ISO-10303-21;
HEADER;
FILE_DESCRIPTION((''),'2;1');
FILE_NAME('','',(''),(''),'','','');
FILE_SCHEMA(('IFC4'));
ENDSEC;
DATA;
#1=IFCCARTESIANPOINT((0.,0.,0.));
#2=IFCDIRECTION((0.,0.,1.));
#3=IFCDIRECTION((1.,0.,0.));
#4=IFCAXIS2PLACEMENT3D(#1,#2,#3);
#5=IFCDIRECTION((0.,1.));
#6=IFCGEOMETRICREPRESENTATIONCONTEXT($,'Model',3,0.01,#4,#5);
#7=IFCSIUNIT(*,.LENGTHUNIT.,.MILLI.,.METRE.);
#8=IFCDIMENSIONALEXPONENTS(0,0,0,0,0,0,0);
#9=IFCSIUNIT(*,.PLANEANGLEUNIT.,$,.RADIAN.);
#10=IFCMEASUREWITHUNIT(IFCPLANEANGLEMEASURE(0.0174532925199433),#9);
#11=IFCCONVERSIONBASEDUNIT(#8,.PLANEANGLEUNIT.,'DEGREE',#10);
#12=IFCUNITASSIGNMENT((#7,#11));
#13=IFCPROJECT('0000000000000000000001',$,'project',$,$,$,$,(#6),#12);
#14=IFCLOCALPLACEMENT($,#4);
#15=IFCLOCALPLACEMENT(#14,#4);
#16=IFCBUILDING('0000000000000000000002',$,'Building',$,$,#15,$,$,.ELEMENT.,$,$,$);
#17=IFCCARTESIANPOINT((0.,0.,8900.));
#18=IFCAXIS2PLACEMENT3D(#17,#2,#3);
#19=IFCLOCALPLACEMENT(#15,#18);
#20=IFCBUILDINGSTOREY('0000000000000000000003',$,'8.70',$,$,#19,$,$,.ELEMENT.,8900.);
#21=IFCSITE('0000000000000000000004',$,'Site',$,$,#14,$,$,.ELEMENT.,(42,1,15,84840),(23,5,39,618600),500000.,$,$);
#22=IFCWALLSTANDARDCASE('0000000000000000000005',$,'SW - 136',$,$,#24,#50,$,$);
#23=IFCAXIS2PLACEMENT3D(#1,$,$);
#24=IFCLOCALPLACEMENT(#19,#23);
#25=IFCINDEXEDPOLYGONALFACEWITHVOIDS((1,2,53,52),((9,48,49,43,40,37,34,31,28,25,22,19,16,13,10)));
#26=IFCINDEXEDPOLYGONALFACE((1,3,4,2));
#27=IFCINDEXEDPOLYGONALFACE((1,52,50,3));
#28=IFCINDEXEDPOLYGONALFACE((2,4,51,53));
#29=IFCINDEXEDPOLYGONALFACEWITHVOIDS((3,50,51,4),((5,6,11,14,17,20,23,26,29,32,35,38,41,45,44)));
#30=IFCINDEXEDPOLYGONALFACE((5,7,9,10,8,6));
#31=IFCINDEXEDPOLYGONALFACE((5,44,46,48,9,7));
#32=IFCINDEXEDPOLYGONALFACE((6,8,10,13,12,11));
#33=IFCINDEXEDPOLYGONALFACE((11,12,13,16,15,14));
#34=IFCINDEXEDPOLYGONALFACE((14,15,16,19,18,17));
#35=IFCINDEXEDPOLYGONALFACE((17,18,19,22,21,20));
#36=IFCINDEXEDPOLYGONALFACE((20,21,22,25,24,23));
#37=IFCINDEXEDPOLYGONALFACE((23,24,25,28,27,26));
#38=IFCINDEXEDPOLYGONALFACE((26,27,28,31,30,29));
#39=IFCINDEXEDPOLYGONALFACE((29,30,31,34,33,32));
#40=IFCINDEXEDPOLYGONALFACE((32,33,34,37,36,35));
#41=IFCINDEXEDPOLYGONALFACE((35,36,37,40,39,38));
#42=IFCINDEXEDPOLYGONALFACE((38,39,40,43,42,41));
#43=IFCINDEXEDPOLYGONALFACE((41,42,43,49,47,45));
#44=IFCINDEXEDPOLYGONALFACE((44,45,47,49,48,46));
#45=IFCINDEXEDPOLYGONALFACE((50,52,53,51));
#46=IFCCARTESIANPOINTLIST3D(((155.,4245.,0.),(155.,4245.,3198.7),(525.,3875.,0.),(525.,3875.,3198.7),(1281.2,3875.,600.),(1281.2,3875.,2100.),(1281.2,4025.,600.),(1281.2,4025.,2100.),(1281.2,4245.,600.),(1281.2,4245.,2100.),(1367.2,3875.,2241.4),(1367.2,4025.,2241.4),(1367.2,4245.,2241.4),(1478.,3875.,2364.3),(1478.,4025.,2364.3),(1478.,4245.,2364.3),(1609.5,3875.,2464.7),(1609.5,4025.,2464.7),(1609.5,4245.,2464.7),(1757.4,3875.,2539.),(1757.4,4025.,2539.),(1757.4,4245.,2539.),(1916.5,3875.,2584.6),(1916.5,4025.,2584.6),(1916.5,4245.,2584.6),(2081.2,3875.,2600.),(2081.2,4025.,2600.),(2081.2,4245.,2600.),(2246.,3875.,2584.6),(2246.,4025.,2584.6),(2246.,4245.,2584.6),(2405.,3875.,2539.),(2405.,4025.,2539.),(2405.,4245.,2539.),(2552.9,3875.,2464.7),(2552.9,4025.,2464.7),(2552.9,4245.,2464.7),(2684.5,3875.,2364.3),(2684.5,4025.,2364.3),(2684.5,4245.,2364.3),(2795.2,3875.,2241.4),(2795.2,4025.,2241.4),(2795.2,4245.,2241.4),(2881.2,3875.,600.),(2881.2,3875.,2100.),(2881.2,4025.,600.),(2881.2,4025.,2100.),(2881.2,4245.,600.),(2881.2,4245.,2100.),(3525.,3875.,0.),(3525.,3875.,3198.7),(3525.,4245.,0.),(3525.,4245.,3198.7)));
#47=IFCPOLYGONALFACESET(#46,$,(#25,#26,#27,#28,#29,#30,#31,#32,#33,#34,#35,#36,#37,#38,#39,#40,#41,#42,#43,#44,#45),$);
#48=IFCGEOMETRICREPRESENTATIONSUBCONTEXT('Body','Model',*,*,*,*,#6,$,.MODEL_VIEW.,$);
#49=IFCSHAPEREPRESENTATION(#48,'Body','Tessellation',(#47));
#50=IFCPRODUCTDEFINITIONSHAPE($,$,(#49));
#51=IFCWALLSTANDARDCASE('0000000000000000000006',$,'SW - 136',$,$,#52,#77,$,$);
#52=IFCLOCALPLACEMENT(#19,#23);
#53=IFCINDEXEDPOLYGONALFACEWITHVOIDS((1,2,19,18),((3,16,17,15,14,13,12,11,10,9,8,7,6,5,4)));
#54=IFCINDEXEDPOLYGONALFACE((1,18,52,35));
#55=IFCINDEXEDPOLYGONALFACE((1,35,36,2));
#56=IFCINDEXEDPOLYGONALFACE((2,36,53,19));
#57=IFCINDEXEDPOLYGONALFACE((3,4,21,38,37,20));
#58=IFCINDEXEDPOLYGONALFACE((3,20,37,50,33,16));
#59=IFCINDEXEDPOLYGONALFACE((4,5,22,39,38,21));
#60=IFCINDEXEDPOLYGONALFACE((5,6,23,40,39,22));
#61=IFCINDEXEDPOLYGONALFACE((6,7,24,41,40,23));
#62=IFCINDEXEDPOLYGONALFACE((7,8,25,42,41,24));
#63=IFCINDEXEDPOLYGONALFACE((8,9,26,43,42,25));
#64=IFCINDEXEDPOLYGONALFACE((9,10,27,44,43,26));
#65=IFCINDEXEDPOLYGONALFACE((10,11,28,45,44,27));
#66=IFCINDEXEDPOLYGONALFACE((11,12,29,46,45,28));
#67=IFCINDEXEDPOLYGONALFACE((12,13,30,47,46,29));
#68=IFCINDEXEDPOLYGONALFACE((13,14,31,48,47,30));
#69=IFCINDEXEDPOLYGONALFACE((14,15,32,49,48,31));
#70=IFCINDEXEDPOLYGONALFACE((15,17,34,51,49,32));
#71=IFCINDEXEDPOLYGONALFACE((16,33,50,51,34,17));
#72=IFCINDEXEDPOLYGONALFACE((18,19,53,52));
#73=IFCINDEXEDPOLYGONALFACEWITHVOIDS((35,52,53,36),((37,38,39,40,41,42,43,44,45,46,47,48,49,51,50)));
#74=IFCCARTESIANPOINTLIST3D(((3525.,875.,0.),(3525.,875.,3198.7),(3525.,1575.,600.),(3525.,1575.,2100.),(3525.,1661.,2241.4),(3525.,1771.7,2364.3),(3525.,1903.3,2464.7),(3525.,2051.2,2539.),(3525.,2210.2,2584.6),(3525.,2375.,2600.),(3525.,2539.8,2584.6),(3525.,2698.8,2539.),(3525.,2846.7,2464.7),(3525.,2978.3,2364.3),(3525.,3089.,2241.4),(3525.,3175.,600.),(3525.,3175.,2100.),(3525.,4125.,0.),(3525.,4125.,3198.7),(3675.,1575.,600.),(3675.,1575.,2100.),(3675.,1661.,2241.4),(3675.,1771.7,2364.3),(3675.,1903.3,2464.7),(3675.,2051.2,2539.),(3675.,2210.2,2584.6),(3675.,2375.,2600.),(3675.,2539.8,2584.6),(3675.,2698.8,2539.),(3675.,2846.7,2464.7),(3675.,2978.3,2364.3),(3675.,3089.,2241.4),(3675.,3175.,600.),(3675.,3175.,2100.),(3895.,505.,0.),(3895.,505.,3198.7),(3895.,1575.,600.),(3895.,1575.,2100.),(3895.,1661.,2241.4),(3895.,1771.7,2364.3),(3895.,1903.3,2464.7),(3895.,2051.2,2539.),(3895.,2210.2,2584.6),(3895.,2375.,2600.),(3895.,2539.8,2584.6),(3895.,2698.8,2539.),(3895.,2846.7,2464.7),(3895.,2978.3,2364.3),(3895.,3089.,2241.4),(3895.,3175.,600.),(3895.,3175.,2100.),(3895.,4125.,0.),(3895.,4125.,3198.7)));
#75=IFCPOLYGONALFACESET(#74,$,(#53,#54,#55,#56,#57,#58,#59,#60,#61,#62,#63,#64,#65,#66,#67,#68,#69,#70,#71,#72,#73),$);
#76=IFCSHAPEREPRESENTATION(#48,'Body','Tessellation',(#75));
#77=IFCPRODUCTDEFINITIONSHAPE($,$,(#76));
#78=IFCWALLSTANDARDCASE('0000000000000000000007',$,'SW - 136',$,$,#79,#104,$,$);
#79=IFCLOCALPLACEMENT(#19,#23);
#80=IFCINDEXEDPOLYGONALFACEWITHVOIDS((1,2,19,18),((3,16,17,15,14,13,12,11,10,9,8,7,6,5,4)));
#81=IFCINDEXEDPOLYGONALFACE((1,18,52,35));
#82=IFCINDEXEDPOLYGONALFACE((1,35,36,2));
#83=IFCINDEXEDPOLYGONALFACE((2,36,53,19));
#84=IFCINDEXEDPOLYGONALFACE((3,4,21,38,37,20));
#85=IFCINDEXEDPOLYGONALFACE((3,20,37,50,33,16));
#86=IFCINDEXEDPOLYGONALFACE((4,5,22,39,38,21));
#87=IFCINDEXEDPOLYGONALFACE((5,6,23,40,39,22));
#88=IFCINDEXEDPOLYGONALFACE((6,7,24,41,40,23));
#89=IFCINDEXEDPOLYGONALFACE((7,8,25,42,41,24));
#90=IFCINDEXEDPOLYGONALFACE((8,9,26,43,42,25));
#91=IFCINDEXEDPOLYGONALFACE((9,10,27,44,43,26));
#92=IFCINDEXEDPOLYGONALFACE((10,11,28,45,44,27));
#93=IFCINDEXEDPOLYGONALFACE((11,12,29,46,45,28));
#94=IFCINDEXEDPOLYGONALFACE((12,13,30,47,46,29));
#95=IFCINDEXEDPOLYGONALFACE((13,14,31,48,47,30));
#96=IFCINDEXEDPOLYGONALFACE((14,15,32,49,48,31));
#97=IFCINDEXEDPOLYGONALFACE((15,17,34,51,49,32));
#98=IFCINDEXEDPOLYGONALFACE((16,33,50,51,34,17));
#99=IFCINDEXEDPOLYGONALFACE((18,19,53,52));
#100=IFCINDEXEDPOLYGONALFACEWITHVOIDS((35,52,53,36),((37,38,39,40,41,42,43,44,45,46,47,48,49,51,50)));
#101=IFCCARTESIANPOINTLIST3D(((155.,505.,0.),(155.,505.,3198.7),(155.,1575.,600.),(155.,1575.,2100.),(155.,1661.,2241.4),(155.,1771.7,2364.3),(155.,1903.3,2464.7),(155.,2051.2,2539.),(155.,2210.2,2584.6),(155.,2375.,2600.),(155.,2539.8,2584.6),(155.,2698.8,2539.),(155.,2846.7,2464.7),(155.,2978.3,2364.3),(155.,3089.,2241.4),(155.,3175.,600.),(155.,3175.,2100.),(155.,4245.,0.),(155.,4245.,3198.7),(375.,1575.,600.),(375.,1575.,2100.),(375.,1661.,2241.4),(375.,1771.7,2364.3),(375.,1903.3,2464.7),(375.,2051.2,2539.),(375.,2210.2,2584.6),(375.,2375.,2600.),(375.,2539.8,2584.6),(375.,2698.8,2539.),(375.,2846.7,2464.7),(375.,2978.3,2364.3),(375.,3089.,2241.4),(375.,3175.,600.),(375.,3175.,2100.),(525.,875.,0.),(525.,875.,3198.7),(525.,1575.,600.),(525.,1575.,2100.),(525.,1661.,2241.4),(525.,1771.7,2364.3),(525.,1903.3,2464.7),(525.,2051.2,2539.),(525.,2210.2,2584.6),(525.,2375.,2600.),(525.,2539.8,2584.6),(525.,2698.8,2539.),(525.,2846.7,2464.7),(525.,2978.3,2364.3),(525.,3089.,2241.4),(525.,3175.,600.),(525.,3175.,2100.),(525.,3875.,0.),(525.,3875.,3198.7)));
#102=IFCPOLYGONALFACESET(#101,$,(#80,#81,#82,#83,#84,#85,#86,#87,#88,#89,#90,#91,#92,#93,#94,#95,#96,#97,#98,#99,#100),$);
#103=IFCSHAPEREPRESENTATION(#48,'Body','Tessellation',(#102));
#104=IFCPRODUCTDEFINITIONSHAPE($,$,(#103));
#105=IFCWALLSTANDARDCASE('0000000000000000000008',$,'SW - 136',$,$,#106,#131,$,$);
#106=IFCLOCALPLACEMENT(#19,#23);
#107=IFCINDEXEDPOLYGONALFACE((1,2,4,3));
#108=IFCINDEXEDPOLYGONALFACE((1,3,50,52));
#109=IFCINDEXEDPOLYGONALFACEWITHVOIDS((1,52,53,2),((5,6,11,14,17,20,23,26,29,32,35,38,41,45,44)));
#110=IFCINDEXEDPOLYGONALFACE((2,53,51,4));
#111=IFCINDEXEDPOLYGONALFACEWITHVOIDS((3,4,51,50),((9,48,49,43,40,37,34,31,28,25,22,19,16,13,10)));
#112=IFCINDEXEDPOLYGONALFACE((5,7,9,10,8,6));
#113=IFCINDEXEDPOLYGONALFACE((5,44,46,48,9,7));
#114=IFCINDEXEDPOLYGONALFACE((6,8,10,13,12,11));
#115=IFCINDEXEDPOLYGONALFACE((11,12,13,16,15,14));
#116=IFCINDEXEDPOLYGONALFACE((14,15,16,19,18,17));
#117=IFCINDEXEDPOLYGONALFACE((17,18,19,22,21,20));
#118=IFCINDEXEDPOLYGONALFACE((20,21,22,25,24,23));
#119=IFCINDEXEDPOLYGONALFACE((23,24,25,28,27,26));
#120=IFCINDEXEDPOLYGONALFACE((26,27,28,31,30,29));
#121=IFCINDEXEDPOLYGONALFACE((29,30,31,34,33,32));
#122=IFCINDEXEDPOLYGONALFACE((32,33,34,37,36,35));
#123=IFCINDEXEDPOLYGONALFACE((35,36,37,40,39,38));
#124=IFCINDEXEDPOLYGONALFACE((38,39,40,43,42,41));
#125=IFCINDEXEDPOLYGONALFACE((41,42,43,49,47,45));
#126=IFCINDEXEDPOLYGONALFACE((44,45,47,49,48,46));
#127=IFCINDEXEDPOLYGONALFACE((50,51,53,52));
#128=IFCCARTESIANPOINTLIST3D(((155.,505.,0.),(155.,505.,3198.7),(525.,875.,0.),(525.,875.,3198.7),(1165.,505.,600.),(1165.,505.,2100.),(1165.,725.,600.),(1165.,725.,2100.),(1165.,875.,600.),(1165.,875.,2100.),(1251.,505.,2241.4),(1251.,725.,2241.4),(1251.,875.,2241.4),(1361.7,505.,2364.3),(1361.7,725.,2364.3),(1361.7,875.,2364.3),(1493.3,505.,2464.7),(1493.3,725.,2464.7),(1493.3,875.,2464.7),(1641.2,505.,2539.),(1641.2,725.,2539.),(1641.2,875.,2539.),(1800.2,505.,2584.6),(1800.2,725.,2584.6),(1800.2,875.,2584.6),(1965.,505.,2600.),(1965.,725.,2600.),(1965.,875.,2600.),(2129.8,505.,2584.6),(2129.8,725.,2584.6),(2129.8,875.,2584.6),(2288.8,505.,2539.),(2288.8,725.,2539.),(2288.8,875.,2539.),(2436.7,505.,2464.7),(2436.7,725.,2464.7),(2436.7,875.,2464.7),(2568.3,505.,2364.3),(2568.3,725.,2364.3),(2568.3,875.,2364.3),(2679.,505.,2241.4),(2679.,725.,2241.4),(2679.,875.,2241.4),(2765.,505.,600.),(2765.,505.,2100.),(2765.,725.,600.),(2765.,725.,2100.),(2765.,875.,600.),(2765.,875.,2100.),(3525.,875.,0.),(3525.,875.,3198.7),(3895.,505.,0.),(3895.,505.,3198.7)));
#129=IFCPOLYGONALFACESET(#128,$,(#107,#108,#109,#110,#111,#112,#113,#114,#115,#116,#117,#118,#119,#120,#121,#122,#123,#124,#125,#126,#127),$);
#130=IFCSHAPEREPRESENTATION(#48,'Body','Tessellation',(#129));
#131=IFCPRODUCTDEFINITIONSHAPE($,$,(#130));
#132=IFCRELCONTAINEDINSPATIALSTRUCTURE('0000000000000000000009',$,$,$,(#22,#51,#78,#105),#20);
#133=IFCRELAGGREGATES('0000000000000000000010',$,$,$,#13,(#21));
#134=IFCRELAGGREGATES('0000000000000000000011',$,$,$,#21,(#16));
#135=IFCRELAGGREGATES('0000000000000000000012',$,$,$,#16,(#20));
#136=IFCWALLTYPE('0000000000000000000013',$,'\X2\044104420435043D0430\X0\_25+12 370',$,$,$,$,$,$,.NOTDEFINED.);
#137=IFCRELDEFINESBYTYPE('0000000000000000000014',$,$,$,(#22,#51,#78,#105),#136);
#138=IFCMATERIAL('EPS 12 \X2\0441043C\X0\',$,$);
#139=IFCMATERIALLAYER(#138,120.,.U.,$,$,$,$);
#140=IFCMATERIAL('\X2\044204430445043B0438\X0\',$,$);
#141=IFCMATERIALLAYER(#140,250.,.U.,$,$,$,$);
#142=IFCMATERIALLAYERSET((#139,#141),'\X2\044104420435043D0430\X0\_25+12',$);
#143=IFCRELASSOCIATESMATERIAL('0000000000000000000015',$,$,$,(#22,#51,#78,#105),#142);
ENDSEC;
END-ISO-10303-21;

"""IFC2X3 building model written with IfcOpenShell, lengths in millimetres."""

from ifc_helpers import new_model, entity, si_unit, converted_unit, direction, frame, origin_with_axes, place, context, subcontext, project, spatial, polyline, outline, extrude, material, layer, layer_set, layer_usage, type_object, element, save


model = new_model("IFC2X3")

# Units and contexts
model_context = context("Model", 3, precision=0.01, world=origin_with_axes(), true_north=direction((0.0, 1.0)))
body_context = subcontext(model_context, "Body", "Model", "MODEL_VIEW")
ifc_project = project(units=[si_unit("LENGTHUNIT", "METRE", prefix="MILLI"), converted_unit("PLANEANGLEUNIT", "DEGREE", entity("IfcPlaneAngleMeasure", 0.0174532925199433), si_unit("PLANEANGLEUNIT", "RADIAN"), dimensions=[0, 0, 0, 0, 0, 0, 0])], contexts=[model_context])

# Site, building, storey
site_placement = place(None, origin_with_axes())
site = spatial("IfcSite", under=ifc_project, at=site_placement, Name="Site", CompositionType="ELEMENT", RefLatitude=(42, 1, 15, 84840), RefLongitude=(23, 5, 39, 618600), RefElevation=500000.0)
building_placement = place(site_placement, origin_with_axes())
building = spatial("IfcBuilding", under=site, at=building_placement, Name="Building", CompositionType="ELEMENT")
storey_placement = place(building_placement, frame((0.0, 0.0, 8900.0), z_axis=(0.0, 0.0, 1.0), x_axis=(1.0, 0.0, 0.0)))
storey = spatial("IfcBuildingStorey", under=building, at=storey_placement, Name="8.70", CompositionType="ELEMENT", Elevation=8900.0)

# Shared definitions
ifc_material_1 = material(Name="EPS 12 см")
ifc_layer_1 = layer(ifc_material_1, 120.0, ventilated="UNKNOWN")
ifc_material_2 = material(Name="тухли")
ifc_layer_2 = layer(ifc_material_2, 250.0, ventilated="UNKNOWN")
ifc_layer_set_1 = layer_set([ifc_layer_1, ifc_layer_2], Name="стена_25+12")
wall_type = type_object("IfcWallType", Name="стена_25+12 370", PredefinedType="NOTDEFINED")

# Walls, openings
ifc_layer_usage_1 = layer_usage(ifc_layer_set_1, "AXIS2", "POSITIVE", -120.0)
wall_1_placement = place(storey_placement, frame((3775.0, 4125.0, 0.0), z_axis=(0.0, 0.0, 1.0), x_axis=(-1.0, 0.0, 0.0)))
wall_1 = element("IfcWallStandardCase", 1, at=wall_1_placement, inside=storey, type_object=wall_type, material=ifc_layer_usage_1, Name="SW - 136", context=body_context, shape_type="SweptSolid", body=[
    extrude(outline(polyline([(250.0, -120.0), (3620.0, -120.0), (3250.0, 250.0), (250.0, 250.0), (250.0, -120.0)])), origin_with_axes(), (0.0, 0.0, 1.0), 3198.7),
])
opening_1_placement = place(wall_1_placement, frame((1693.8, 0.0, 600.0), z_axis=(0.0, 0.0, 1.0), x_axis=(1.0, 0.0, 0.0)))
element("IfcOpeningElement", 2, at=opening_1_placement, cuts=wall_1, context=body_context, shape_type="SweptSolid", body=[
    extrude(outline(polyline([(-800.0, 0.0), (-800.0, -1500.0), (-714.0, -1641.4), (-603.3, -1764.3), (-471.7, -1864.7), (-323.8, -1939.0), (-164.8, -1984.6), (0.0, -2000.0), (164.8, -1984.6), (323.8, -1939.0), (471.7, -1864.7), (603.3, -1764.3), (714.0, -1641.4), (800.0, -1500.0), (800.0, 0.0), (-800.0, 0.0)])), frame((0.0, 100.0, 0.0), z_axis=(0.0, 1.0, 0.0), x_axis=(1.0, 0.0, 0.0)), (0.0, 0.0, -1.0), 590.0),
    extrude(outline(polyline([(800.0, 0.0), (800.0, 1500.0), (714.0, 1641.4), (603.3, 1764.3), (471.7, 1864.7), (323.8, 1939.0), (164.8, 1984.6), (0.0, 2000.0), (-164.8, 1984.6), (-323.8, 1939.0), (-471.7, 1864.7), (-603.3, 1764.3), (-714.0, 1641.4), (-800.0, 1500.0), (-800.0, 0.0), (800.0, 0.0)])), frame((0.0, 100.0, 0.0), z_axis=(0.0, -1.0, 0.0), x_axis=(1.0, 0.0, 0.0)), (0.0, 0.0, -1.0), 520.0),
])
ifc_layer_usage_2 = layer_usage(ifc_layer_set_1, "AXIS2", "NEGATIVE", 120.0)
wall_2_placement = place(storey_placement, frame((3775.0, 4125.0, 0.0), z_axis=(0.0, 0.0, 1.0), x_axis=(0.0, -1.0, 0.0)))
wall_2 = element("IfcWallStandardCase", 3, at=wall_2_placement, inside=storey, type_object=wall_type, material=ifc_layer_usage_2, Name="SW - 136", context=body_context, shape_type="SweptSolid", body=[
    extrude(outline(polyline([(0.0, -250.0), (3250.0, -250.0), (3620.0, 120.0), (0.0, 120.0), (0.0, -250.0)])), origin_with_axes(), (0.0, 0.0, 1.0), 3198.7),
])
opening_2_placement = place(wall_2_placement, frame((1750.0, 0.0, 600.0), z_axis=(0.0, 0.0, 1.0), x_axis=(1.0, 0.0, 0.0)))
element("IfcOpeningElement", 4, at=opening_2_placement, cuts=wall_2, context=body_context, shape_type="SweptSolid", body=[
    extrude(outline(polyline([(-800.0, 0.0), (-800.0, -1500.0), (-714.0, -1641.4), (-603.3, -1764.3), (-471.7, -1864.7), (-323.8, -1939.0), (-164.8, -1984.6), (0.0, -2000.0), (164.8, -1984.6), (323.8, -1939.0), (471.7, -1864.7), (603.3, -1764.3), (714.0, -1641.4), (800.0, -1500.0), (800.0, 0.0), (-800.0, 0.0)])), frame((0.0, -100.0, 0.0), z_axis=(0.0, 1.0, 0.0), x_axis=(1.0, 0.0, 0.0)), (0.0, 0.0, 1.0), 590.0),
    extrude(outline(polyline([(800.0, 0.0), (800.0, 1500.0), (714.0, 1641.4), (603.3, 1764.3), (471.7, 1864.7), (323.8, 1939.0), (164.8, 1984.6), (0.0, 2000.0), (-164.8, 1984.6), (-323.8, 1939.0), (-471.7, 1864.7), (-603.3, 1764.3), (-714.0, 1641.4), (-800.0, 1500.0), (-800.0, 0.0), (800.0, 0.0)])), frame((0.0, -100.0, 0.0), z_axis=(0.0, -1.0, 0.0), x_axis=(1.0, 0.0, 0.0)), (0.0, 0.0, 1.0), 520.0),
])
ifc_layer_usage_3 = layer_usage(ifc_layer_set_1, "AXIS2", "POSITIVE", -120.0)
wall_3_placement = place(storey_placement, frame((275.0, 4125.0, 0.0), z_axis=(0.0, 0.0, 1.0), x_axis=(0.0, -1.0, 0.0)))
wall_3 = element("IfcWallStandardCase", 5, at=wall_3_placement, inside=storey, type_object=wall_type, material=ifc_layer_usage_3, Name="SW - 136", context=body_context, shape_type="SweptSolid", body=[
    extrude(outline(polyline([(-120.0, -120.0), (3620.0, -120.0), (3250.0, 250.0), (250.0, 250.0), (-120.0, -120.0)])), origin_with_axes(), (0.0, 0.0, 1.0), 3198.7),
])
opening_3_placement = place(wall_3_placement, frame((1750.0, 0.0, 600.0), z_axis=(0.0, 0.0, 1.0), x_axis=(1.0, 0.0, 0.0)))
element("IfcOpeningElement", 6, at=opening_3_placement, cuts=wall_3, context=body_context, shape_type="SweptSolid", body=[
    extrude(outline(polyline([(-800.0, 0.0), (-800.0, -1500.0), (-714.0, -1641.4), (-603.3, -1764.3), (-471.7, -1864.7), (-323.8, -1939.0), (-164.8, -1984.6), (0.0, -2000.0), (164.8, -1984.6), (323.8, -1939.0), (471.7, -1864.7), (603.3, -1764.3), (714.0, -1641.4), (800.0, -1500.0), (800.0, 0.0), (-800.0, 0.0)])), frame((0.0, 100.0, 0.0), z_axis=(0.0, 1.0, 0.0), x_axis=(1.0, 0.0, 0.0)), (0.0, 0.0, -1.0), 590.0),
    extrude(outline(polyline([(800.0, 0.0), (800.0, 1500.0), (714.0, 1641.4), (603.3, 1764.3), (471.7, 1864.7), (323.8, 1939.0), (164.8, 1984.6), (0.0, 2000.0), (-164.8, 1984.6), (-323.8, 1939.0), (-471.7, 1864.7), (-603.3, 1764.3), (-714.0, 1641.4), (-800.0, 1500.0), (-800.0, 0.0), (800.0, 0.0)])), frame((0.0, 100.0, 0.0), z_axis=(0.0, -1.0, 0.0), x_axis=(1.0, 0.0, 0.0)), (0.0, 0.0, -1.0), 520.0),
])
ifc_layer_usage_4 = layer_usage(ifc_layer_set_1, "AXIS2", "POSITIVE", -120.0)
wall_4_placement = place(storey_placement, frame((275.0, 625.0, 0.0), z_axis=(0.0, 0.0, 1.0), x_axis=(1.0, 0.0, 0.0)))
wall_4 = element("IfcWallStandardCase", 7, at=wall_4_placement, inside=storey, type_object=wall_type, material=ifc_layer_usage_4, Name="SW - 136", context=body_context, shape_type="SweptSolid", body=[
    extrude(outline(polyline([(-120.0, -120.0), (3620.0, -120.0), (3250.0, 250.0), (250.0, 250.0), (-120.0, -120.0)])), origin_with_axes(), (0.0, 0.0, 1.0), 3198.7),
])
opening_4_placement = place(wall_4_placement, frame((1690.0, 0.0, 600.0), z_axis=(0.0, 0.0, 1.0), x_axis=(1.0, 0.0, 0.0)))
element("IfcOpeningElement", 8, at=opening_4_placement, cuts=wall_4, context=body_context, shape_type="SweptSolid", body=[
    extrude(outline(polyline([(-800.0, 0.0), (-800.0, -1500.0), (-714.0, -1641.4), (-603.3, -1764.3), (-471.7, -1864.7), (-323.8, -1939.0), (-164.8, -1984.6), (0.0, -2000.0), (164.8, -1984.6), (323.8, -1939.0), (471.7, -1864.7), (603.3, -1764.3), (714.0, -1641.4), (800.0, -1500.0), (800.0, 0.0), (-800.0, 0.0)])), frame((0.0, 100.0, 0.0), z_axis=(0.0, 1.0, 0.0), x_axis=(1.0, 0.0, 0.0)), (0.0, 0.0, -1.0), 590.0),
    extrude(outline(polyline([(800.0, 0.0), (800.0, 1500.0), (714.0, 1641.4), (603.3, 1764.3), (471.7, 1864.7), (323.8, 1939.0), (164.8, 1984.6), (0.0, 2000.0), (-164.8, 1984.6), (-323.8, 1939.0), (-471.7, 1864.7), (-603.3, 1764.3), (-714.0, 1641.4), (-800.0, 1500.0), (-800.0, 0.0), (800.0, 0.0)])), frame((0.0, 100.0, 0.0), z_axis=(0.0, -1.0, 0.0), x_axis=(1.0, 0.0, 0.0)), (0.0, 0.0, -1.0), 520.0),
])

save(model, "model.ifc")
